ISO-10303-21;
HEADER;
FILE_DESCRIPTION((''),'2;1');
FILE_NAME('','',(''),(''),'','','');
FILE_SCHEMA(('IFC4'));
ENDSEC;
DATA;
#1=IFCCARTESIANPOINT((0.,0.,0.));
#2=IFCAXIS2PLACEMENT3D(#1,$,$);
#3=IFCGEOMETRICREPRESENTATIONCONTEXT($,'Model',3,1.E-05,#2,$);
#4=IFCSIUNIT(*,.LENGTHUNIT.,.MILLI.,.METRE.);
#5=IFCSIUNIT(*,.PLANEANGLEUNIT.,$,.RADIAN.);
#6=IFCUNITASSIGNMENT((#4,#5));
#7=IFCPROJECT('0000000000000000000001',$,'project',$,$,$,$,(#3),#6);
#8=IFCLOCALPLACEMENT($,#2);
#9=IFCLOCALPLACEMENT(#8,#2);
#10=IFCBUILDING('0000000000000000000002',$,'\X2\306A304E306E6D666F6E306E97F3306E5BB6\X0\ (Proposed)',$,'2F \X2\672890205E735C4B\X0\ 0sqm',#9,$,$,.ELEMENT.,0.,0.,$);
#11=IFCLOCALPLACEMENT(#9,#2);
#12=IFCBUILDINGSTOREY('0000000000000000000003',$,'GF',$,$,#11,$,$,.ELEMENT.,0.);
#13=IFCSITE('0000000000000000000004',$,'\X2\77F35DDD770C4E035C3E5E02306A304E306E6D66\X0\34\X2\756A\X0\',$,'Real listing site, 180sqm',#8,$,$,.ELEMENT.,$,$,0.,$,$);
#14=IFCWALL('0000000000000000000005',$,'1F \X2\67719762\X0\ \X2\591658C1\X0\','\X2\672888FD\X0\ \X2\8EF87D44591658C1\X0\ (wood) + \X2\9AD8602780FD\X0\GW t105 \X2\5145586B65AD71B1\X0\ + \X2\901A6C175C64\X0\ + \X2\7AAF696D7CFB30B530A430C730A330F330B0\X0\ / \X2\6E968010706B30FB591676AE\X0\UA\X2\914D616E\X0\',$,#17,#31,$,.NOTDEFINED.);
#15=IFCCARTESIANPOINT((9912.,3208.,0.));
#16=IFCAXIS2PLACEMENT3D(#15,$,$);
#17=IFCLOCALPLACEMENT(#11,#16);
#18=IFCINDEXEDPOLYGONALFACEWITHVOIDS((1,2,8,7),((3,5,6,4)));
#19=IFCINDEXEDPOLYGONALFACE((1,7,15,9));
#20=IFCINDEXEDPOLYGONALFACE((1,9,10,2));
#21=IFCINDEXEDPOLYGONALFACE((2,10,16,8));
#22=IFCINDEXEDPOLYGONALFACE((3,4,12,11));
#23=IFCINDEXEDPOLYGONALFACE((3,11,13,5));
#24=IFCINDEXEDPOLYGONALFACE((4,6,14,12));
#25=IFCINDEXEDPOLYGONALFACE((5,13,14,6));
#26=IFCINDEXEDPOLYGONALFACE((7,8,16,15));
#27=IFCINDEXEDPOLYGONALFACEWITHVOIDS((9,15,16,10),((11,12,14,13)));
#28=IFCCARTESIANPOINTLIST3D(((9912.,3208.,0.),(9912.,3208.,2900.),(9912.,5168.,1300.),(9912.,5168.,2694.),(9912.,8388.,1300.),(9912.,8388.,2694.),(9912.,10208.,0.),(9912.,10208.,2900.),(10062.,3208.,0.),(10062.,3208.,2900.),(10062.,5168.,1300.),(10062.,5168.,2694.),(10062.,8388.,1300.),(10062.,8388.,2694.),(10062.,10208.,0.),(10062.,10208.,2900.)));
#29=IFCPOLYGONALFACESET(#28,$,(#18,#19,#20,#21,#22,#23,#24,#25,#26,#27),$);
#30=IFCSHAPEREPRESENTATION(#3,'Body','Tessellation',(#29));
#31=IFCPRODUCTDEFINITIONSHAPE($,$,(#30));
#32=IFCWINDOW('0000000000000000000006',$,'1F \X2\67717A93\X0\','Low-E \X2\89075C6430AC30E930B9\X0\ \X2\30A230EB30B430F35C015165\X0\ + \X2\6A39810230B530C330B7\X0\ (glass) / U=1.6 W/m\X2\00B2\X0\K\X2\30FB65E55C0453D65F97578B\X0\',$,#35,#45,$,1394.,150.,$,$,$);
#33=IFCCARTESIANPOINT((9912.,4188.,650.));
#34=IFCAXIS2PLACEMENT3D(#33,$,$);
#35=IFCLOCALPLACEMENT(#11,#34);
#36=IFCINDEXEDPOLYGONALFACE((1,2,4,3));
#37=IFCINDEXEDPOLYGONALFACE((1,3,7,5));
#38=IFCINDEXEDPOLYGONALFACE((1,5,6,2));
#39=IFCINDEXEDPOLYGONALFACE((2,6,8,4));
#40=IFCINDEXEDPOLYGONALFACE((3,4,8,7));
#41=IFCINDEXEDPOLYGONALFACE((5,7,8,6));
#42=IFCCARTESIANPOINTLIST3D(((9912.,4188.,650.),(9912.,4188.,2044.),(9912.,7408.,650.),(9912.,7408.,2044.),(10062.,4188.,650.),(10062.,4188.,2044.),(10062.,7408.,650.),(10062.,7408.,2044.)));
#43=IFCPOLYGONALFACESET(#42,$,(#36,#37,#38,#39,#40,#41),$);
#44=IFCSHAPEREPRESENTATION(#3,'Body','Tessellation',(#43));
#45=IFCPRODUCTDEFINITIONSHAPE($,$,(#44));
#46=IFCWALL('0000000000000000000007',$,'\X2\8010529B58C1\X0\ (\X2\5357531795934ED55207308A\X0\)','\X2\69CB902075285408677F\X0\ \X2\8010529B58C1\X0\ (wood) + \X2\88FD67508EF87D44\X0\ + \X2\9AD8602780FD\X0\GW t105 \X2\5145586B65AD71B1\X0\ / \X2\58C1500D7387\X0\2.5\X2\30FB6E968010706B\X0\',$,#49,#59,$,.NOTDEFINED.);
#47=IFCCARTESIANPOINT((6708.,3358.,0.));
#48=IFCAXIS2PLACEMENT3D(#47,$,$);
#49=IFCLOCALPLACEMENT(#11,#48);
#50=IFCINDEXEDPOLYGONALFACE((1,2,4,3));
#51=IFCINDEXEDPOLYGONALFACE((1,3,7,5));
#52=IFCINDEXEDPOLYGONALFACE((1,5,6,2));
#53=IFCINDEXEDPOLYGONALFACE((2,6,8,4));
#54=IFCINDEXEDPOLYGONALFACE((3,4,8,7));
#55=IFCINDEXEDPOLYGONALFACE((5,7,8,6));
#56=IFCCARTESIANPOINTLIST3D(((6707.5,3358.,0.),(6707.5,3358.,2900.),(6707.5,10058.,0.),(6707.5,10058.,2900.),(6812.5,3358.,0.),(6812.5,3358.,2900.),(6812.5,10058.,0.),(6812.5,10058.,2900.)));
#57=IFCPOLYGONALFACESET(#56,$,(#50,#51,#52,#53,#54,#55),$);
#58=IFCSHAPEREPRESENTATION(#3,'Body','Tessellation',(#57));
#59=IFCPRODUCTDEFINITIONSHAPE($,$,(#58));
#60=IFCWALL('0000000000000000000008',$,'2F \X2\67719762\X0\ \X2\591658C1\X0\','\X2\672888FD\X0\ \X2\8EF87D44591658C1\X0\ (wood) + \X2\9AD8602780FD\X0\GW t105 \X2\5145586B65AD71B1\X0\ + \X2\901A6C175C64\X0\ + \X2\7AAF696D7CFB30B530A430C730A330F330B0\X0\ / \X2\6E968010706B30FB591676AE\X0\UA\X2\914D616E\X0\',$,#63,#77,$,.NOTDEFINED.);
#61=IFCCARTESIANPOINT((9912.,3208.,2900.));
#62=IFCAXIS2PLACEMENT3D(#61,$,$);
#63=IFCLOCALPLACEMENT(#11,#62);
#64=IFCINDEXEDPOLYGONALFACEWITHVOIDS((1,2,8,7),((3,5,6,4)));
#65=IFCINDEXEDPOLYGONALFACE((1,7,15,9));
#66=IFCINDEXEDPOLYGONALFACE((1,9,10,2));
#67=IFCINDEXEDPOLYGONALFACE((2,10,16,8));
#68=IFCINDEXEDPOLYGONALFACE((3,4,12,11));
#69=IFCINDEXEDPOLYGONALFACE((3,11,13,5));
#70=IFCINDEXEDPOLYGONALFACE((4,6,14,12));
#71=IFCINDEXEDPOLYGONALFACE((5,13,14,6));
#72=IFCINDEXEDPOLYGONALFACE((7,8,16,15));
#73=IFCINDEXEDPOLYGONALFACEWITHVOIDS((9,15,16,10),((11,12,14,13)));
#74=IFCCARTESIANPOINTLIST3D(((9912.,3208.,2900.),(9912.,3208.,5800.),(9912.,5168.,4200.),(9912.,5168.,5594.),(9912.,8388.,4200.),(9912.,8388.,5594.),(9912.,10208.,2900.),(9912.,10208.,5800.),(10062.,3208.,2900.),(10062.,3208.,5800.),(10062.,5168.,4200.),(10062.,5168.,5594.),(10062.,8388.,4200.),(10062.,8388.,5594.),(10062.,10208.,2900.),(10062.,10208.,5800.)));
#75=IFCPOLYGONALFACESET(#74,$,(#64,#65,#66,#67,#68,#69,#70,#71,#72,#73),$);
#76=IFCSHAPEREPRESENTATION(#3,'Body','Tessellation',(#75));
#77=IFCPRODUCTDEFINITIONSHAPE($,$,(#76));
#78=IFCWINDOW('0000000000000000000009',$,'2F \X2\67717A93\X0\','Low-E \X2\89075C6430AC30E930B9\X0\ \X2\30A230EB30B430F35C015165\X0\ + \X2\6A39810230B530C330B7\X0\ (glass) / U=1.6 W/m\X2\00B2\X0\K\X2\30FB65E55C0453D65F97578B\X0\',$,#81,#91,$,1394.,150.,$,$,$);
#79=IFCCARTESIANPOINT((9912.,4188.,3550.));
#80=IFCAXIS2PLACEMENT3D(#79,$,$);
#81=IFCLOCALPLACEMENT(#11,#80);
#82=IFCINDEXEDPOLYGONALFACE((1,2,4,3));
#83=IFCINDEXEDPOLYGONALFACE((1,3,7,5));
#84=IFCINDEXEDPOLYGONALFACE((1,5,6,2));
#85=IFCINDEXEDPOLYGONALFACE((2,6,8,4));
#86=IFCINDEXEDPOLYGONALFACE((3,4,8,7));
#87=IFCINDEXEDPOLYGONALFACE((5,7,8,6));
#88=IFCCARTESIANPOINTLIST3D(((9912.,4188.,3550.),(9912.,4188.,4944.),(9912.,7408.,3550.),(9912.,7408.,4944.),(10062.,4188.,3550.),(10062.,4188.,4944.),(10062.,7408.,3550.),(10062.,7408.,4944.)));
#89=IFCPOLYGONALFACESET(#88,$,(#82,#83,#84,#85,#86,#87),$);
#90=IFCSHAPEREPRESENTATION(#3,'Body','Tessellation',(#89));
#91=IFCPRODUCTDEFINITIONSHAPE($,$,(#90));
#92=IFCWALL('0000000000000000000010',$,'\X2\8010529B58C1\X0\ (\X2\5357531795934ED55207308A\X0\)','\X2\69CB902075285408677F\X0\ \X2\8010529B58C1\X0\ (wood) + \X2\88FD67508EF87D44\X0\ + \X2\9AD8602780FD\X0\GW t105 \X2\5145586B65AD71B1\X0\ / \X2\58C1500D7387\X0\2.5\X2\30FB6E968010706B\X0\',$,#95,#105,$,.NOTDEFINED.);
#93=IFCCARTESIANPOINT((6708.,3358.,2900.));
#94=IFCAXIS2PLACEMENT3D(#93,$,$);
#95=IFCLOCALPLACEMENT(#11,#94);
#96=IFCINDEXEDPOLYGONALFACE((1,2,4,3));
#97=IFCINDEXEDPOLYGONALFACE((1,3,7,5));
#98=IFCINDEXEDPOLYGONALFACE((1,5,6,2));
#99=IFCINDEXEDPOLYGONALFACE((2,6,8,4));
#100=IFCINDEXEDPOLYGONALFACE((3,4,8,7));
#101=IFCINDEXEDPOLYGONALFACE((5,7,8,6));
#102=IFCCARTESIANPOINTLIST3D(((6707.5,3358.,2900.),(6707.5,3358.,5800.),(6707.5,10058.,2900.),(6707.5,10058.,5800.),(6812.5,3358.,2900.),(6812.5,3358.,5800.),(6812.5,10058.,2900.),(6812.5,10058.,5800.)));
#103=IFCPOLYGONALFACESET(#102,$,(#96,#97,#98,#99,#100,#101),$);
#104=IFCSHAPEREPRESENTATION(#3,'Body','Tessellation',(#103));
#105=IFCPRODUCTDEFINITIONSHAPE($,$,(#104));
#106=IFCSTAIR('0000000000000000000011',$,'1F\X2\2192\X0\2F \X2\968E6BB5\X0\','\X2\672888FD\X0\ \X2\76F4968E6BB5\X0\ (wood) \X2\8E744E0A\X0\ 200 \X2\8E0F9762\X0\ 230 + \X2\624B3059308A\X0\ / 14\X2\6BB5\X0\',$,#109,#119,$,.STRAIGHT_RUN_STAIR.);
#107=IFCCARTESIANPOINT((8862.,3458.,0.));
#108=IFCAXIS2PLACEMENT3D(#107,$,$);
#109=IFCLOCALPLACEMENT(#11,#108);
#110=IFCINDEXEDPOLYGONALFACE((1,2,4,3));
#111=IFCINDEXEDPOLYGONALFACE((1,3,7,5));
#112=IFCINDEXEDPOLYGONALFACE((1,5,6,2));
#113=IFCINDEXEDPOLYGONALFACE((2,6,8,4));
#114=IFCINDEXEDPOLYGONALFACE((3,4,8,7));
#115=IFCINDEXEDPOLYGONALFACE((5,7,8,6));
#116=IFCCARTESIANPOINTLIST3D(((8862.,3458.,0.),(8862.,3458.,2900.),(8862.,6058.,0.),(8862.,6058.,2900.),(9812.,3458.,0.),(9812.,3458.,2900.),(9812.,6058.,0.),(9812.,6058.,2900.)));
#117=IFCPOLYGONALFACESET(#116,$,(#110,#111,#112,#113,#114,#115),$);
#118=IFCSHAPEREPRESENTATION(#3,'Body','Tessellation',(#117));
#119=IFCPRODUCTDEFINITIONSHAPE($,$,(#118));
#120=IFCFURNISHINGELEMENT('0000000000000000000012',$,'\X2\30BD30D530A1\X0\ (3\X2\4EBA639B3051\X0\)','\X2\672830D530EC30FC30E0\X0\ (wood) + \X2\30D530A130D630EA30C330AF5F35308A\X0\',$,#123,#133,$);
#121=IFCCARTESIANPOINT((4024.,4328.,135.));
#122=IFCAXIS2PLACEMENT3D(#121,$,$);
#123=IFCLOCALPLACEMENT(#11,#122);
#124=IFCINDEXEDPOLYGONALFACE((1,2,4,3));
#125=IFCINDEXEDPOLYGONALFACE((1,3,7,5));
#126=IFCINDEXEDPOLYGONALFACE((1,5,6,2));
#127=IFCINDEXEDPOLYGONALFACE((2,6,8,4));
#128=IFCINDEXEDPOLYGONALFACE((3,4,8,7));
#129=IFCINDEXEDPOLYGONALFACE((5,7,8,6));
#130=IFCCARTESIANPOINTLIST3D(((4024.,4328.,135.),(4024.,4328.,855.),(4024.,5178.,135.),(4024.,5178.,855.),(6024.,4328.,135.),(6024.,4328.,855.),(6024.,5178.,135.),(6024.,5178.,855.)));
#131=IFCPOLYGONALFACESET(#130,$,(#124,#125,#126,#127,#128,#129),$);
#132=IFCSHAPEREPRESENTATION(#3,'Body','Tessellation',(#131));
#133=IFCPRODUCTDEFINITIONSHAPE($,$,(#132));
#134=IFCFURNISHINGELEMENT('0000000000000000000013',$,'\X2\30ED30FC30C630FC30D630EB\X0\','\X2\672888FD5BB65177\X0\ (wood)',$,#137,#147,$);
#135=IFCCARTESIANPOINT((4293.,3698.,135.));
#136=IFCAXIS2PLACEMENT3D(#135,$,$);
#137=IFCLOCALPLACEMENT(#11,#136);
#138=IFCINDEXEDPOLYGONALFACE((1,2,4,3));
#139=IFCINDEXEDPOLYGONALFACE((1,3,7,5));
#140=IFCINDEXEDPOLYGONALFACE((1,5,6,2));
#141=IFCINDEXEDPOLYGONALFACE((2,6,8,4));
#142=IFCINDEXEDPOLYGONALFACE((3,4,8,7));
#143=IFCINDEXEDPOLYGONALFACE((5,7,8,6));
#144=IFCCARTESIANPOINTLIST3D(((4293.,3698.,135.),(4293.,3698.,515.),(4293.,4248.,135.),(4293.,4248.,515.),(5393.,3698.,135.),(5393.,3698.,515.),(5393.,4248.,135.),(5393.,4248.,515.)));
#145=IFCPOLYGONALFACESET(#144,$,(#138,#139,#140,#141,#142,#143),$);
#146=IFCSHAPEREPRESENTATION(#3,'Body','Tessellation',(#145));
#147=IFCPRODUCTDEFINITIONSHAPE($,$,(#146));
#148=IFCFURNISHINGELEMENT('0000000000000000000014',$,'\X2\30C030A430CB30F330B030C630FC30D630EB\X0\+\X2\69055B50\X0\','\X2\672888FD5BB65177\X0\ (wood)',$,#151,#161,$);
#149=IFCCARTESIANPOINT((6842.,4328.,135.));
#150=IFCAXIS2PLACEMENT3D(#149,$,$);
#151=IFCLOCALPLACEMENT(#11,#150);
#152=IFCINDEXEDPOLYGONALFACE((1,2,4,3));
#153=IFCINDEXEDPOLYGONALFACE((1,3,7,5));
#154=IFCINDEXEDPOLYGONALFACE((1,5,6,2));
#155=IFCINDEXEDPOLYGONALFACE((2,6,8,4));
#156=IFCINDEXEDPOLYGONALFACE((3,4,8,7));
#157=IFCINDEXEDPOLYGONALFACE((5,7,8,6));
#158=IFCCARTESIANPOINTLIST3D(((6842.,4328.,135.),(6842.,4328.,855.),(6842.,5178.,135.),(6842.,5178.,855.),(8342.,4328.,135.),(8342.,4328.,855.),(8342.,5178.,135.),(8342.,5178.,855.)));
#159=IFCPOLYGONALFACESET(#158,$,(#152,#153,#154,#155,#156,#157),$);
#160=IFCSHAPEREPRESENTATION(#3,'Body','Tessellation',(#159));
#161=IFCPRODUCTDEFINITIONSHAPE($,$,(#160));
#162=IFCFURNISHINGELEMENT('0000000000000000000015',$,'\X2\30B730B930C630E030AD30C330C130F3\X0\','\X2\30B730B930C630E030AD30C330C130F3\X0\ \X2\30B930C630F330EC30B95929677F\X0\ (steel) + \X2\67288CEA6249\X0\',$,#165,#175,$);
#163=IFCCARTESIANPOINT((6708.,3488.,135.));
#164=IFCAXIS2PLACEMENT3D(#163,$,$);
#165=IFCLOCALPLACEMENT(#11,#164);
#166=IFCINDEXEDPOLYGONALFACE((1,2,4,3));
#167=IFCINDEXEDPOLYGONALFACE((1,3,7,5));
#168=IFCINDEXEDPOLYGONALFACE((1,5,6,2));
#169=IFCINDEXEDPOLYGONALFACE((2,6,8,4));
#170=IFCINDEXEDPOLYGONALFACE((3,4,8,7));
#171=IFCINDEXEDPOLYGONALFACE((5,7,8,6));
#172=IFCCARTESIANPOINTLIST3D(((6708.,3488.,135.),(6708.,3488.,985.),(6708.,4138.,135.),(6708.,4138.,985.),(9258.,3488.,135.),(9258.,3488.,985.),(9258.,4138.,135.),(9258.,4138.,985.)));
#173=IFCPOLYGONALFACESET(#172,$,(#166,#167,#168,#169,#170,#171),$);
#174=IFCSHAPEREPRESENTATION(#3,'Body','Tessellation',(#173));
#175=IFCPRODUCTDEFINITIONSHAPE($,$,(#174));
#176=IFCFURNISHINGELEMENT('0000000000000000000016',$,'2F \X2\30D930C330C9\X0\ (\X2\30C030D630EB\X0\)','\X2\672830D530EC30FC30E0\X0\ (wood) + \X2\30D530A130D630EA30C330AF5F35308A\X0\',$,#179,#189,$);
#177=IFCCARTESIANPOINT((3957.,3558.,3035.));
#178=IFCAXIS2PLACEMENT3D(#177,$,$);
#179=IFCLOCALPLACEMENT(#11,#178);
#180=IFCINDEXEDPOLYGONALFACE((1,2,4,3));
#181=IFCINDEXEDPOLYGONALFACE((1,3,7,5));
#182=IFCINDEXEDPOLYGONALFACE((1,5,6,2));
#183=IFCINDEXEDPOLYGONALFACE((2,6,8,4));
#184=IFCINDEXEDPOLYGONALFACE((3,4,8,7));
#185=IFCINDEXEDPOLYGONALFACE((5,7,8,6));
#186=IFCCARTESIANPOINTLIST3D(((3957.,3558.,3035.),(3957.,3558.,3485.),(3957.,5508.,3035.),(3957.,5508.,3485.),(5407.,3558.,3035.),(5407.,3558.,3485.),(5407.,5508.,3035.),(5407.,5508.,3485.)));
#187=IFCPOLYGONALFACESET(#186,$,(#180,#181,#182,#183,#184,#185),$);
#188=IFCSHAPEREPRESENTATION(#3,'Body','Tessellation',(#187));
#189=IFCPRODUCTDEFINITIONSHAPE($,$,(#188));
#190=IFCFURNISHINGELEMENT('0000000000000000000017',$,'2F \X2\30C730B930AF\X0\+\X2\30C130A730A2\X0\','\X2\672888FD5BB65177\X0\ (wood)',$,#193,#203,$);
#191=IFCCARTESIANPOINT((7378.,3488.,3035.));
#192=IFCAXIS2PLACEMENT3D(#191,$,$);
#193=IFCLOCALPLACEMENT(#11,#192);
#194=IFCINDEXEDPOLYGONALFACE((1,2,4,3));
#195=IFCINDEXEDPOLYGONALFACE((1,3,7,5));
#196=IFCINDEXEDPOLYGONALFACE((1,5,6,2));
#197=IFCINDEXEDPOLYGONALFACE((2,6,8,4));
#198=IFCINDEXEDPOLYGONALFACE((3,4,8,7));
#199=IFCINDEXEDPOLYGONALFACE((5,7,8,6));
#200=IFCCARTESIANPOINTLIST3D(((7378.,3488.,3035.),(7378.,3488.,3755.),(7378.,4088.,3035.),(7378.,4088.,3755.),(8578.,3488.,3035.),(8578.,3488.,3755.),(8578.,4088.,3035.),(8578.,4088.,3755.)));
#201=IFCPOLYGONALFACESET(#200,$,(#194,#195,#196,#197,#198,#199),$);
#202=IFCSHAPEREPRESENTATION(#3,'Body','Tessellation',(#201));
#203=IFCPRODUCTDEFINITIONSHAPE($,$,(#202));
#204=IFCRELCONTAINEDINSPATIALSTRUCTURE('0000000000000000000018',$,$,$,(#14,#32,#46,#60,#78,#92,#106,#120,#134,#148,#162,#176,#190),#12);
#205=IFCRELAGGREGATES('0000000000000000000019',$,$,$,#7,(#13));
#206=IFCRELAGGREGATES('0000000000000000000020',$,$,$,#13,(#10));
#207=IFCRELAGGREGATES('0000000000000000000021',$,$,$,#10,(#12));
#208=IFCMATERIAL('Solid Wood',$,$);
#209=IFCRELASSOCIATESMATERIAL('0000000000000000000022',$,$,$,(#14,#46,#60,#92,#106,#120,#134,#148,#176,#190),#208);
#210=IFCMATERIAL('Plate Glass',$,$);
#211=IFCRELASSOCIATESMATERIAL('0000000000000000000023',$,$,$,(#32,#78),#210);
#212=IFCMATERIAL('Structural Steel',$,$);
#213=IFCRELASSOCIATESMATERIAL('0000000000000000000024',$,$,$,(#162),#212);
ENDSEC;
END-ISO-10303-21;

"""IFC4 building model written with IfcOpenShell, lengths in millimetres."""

from ifc_helpers import new_model, si_unit, frame, frame_2d, origin, place, context, project, spatial, rectangle, extrude, material, element, fill, save


model = new_model("IFC4")

# Units and contexts
model_context = context("Model", 3, precision=1e-05, world=origin())
ifc_project = project(units=[si_unit("LENGTHUNIT", "METRE", prefix="MILLI"), si_unit("PLANEANGLEUNIT", "RADIAN")], contexts=[model_context])

# Site, building, storey
site_placement = place(None, origin())
site = spatial("IfcSite", under=ifc_project, at=site_placement, Name="石川県七尾市なぎの浦34番", ObjectType="Real listing site, 180sqm", CompositionType="ELEMENT", RefElevation=0.0)
building_placement = place(site_placement, origin())
building = spatial("IfcBuilding", under=site, at=building_placement, Name="なぎの浦潮の音の家 (Proposed)", ObjectType="2F 木造平屋 0sqm", CompositionType="ELEMENT", ElevationOfRefHeight=0.0, ElevationOfTerrain=0.0)
storey_placement = place(building_placement, origin())
storey = spatial("IfcBuildingStorey", under=building, at=storey_placement, Name="GF", CompositionType="ELEMENT", Elevation=0.0)

# Wall, opening, window
ifc_material_1 = material(Name="Solid Wood")
wall_1_placement = place(storey_placement, frame((9912.0, 3208.0, 0.0)))
wall_1 = element("IfcWall", 1, at=wall_1_placement, inside=storey, material=ifc_material_1, Name="1F 東面 外壁", Description="木製 軸組外壁 (wood) + 高性能GW t105 充填断熱 + 通気層 + 窯業系サイディング / 準耐火・外皮UA配慮", PredefinedType="NOTDEFINED", context=model_context, shape_type="SweptSolid", body=[
    extrude(rectangle(XDim=150.0, YDim=7000.0, at=frame_2d((75.0, 3500.0))), frame((9912.0, 3208.0, 0.0)), (0.0, 0.0, 1.0), 2900.0),
])
opening_1_placement = place(storey_placement, frame((9912.0, 4188.0, 650.0)))
opening_1 = element("IfcOpeningElement", 2, at=opening_1_placement, cuts=wall_1, PredefinedType="NOTDEFINED", context=model_context, shape_type="SweptSolid", body=[
    extrude(rectangle(XDim=150.0, YDim=3220.0, at=frame_2d((75.0, 1610.0))), frame((9912.0, 4188.0, 650.0)), (0.0, 0.0, 1.0), 1394.0),
])
ifc_material_2 = material(Name="Plate Glass")
window_1_placement = place(storey_placement, frame((9912.0, 4188.0, 650.0)))
window_1 = element("IfcWindow", 3, at=window_1_placement, inside=storey, material=ifc_material_2, Name="1F 東窓", Description="Low-E 複層ガラス アルゴン封入 + 樹脂サッシ (glass) / U=1.6 W/m²K・日射取得型", OverallHeight=1394.0, OverallWidth=150.0, context=model_context, shape_type="SweptSolid", body=[
    extrude(rectangle(XDim=150.0, YDim=3220.0, at=frame_2d((75.0, 1610.0))), frame((9912.0, 4188.0, 650.0)), (0.0, 0.0, 1.0), 1394.0),
])
fill(opening_1, window_1)

# Wall
wall_2_placement = place(storey_placement, frame((6708.0, 3358.0, 0.0)))
element("IfcWall", 4, at=wall_2_placement, inside=storey, material=ifc_material_1, Name="耐力壁 (南北間仕切り)", Description="構造用合板 耐力壁 (wood) + 製材軸組 + 高性能GW t105 充填断熱 / 壁倍率2.5・準耐火", PredefinedType="NOTDEFINED", context=model_context, shape_type="SweptSolid", body=[
    extrude(rectangle(XDim=105.0, YDim=6700.0, at=frame_2d((52.0, 3350.0))), frame((6708.0, 3358.0, 0.0)), (0.0, 0.0, 1.0), 2900.0),
])

# Wall, opening, window
wall_3_placement = place(storey_placement, frame((9912.0, 3208.0, 2900.0)))
wall_3 = element("IfcWall", 5, at=wall_3_placement, inside=storey, material=ifc_material_1, Name="2F 東面 外壁", Description="木製 軸組外壁 (wood) + 高性能GW t105 充填断熱 + 通気層 + 窯業系サイディング / 準耐火・外皮UA配慮", PredefinedType="NOTDEFINED", context=model_context, shape_type="SweptSolid", body=[
    extrude(rectangle(XDim=150.0, YDim=7000.0, at=frame_2d((75.0, 3500.0))), frame((9912.0, 3208.0, 2900.0)), (0.0, 0.0, 1.0), 2900.0),
])
opening_2_placement = place(storey_placement, frame((9912.0, 4188.0, 3550.0)))
opening_2 = element("IfcOpeningElement", 6, at=opening_2_placement, cuts=wall_3, PredefinedType="NOTDEFINED", context=model_context, shape_type="SweptSolid", body=[
    extrude(rectangle(XDim=150.0, YDim=3220.0, at=frame_2d((75.0, 1610.0))), frame((9912.0, 4188.0, 3550.0)), (0.0, 0.0, 1.0), 1394.0),
])
window_2_placement = place(storey_placement, frame((9912.0, 4188.0, 3550.0)))
window_2 = element("IfcWindow", 7, at=window_2_placement, inside=storey, material=ifc_material_2, Name="2F 東窓", Description="Low-E 複層ガラス アルゴン封入 + 樹脂サッシ (glass) / U=1.6 W/m²K・日射取得型", OverallHeight=1394.0, OverallWidth=150.0, context=model_context, shape_type="SweptSolid", body=[
    extrude(rectangle(XDim=150.0, YDim=3220.0, at=frame_2d((75.0, 1610.0))), frame((9912.0, 4188.0, 3550.0)), (0.0, 0.0, 1.0), 1394.0),
])
fill(opening_2, window_2)

# Wall
wall_4_placement = place(storey_placement, frame((6708.0, 3358.0, 2900.0)))
element("IfcWall", 8, at=wall_4_placement, inside=storey, material=ifc_material_1, Name="耐力壁 (南北間仕切り)", Description="構造用合板 耐力壁 (wood) + 製材軸組 + 高性能GW t105 充填断熱 / 壁倍率2.5・準耐火", PredefinedType="NOTDEFINED", context=model_context, shape_type="SweptSolid", body=[
    extrude(rectangle(XDim=105.0, YDim=6700.0, at=frame_2d((52.0, 3350.0))), frame((6708.0, 3358.0, 2900.0)), (0.0, 0.0, 1.0), 2900.0),
])

# Stair
stair_placement = place(storey_placement, frame((8862.0, 3458.0, 0.0)))
element("IfcStair", 9, at=stair_placement, inside=storey, material=ifc_material_1, Name="1F→2F 階段", Description="木製 直階段 (wood) 蹴上 200 踏面 230 + 手すり / 14段", PredefinedType="STRAIGHT_RUN_STAIR", context=model_context, shape_type="SweptSolid", body=[
    extrude(rectangle(XDim=950.0, YDim=2600.0, at=frame_2d((475.0, 1300.0))), frame((8862.0, 3458.0, 0.0)), (0.0, 0.0, 1.0), 2900.0),
])

# Furnishing elements
furnishing_1_placement = place(storey_placement, frame((4024.0, 4328.0, 135.0)))
element("IfcFurnishingElement", 10, at=furnishing_1_placement, inside=storey, material=ifc_material_1, Name="ソファ (3人掛け)", Description="木フレーム (wood) + ファブリック張り", context=model_context, shape_type="SweptSolid", body=[
    extrude(rectangle(XDim=2000.0, YDim=850.0, at=frame_2d((1000.0, 425.0))), frame((4024.0, 4328.0, 135.0)), (0.0, 0.0, 1.0), 720.0),
])
furnishing_2_placement = place(storey_placement, frame((4293.0, 3698.0, 135.0)))
element("IfcFurnishingElement", 11, at=furnishing_2_placement, inside=storey, material=ifc_material_1, Name="ローテーブル", Description="木製家具 (wood)", context=model_context, shape_type="SweptSolid", body=[
    extrude(rectangle(XDim=1100.0, YDim=550.0, at=frame_2d((550.0, 275.0))), frame((4293.0, 3698.0, 135.0)), (0.0, 0.0, 1.0), 380.0),
])
furnishing_3_placement = place(storey_placement, frame((6842.0, 4328.0, 135.0)))
element("IfcFurnishingElement", 12, at=furnishing_3_placement, inside=storey, material=ifc_material_1, Name="ダイニングテーブル+椅子", Description="木製家具 (wood)", context=model_context, shape_type="SweptSolid", body=[
    extrude(rectangle(XDim=1500.0, YDim=850.0, at=frame_2d((750.0, 425.0))), frame((6842.0, 4328.0, 135.0)), (0.0, 0.0, 1.0), 720.0),
])
ifc_material_3 = material(Name="Structural Steel")
furnishing_4_placement = place(storey_placement, frame((6708.0, 3488.0, 135.0)))
element("IfcFurnishingElement", 13, at=furnishing_4_placement, inside=storey, material=ifc_material_3, Name="システムキッチン", Description="システムキッチン ステンレス天板 (steel) + 木質扉", context=model_context, shape_type="SweptSolid", body=[
    extrude(rectangle(XDim=2550.0, YDim=650.0, at=frame_2d((1275.0, 325.0))), frame((6708.0, 3488.0, 135.0)), (0.0, 0.0, 1.0), 850.0),
])
furnishing_5_placement = place(storey_placement, frame((3957.0, 3558.0, 3035.0)))
element("IfcFurnishingElement", 14, at=furnishing_5_placement, inside=storey, material=ifc_material_1, Name="2F ベッド (ダブル)", Description="木フレーム (wood) + ファブリック張り", context=model_context, shape_type="SweptSolid", body=[
    extrude(rectangle(XDim=1450.0, YDim=1950.0, at=frame_2d((725.0, 975.0))), frame((3957.0, 3558.0, 3035.0)), (0.0, 0.0, 1.0), 450.0),
])
furnishing_6_placement = place(storey_placement, frame((7378.0, 3488.0, 3035.0)))
element("IfcFurnishingElement", 15, at=furnishing_6_placement, inside=storey, material=ifc_material_1, Name="2F デスク+チェア", Description="木製家具 (wood)", context=model_context, shape_type="SweptSolid", body=[
    extrude(rectangle(XDim=1200.0, YDim=600.0, at=frame_2d((600.0, 300.0))), frame((7378.0, 3488.0, 3035.0)), (0.0, 0.0, 1.0), 720.0),
])

save(model, "model.ifc")
